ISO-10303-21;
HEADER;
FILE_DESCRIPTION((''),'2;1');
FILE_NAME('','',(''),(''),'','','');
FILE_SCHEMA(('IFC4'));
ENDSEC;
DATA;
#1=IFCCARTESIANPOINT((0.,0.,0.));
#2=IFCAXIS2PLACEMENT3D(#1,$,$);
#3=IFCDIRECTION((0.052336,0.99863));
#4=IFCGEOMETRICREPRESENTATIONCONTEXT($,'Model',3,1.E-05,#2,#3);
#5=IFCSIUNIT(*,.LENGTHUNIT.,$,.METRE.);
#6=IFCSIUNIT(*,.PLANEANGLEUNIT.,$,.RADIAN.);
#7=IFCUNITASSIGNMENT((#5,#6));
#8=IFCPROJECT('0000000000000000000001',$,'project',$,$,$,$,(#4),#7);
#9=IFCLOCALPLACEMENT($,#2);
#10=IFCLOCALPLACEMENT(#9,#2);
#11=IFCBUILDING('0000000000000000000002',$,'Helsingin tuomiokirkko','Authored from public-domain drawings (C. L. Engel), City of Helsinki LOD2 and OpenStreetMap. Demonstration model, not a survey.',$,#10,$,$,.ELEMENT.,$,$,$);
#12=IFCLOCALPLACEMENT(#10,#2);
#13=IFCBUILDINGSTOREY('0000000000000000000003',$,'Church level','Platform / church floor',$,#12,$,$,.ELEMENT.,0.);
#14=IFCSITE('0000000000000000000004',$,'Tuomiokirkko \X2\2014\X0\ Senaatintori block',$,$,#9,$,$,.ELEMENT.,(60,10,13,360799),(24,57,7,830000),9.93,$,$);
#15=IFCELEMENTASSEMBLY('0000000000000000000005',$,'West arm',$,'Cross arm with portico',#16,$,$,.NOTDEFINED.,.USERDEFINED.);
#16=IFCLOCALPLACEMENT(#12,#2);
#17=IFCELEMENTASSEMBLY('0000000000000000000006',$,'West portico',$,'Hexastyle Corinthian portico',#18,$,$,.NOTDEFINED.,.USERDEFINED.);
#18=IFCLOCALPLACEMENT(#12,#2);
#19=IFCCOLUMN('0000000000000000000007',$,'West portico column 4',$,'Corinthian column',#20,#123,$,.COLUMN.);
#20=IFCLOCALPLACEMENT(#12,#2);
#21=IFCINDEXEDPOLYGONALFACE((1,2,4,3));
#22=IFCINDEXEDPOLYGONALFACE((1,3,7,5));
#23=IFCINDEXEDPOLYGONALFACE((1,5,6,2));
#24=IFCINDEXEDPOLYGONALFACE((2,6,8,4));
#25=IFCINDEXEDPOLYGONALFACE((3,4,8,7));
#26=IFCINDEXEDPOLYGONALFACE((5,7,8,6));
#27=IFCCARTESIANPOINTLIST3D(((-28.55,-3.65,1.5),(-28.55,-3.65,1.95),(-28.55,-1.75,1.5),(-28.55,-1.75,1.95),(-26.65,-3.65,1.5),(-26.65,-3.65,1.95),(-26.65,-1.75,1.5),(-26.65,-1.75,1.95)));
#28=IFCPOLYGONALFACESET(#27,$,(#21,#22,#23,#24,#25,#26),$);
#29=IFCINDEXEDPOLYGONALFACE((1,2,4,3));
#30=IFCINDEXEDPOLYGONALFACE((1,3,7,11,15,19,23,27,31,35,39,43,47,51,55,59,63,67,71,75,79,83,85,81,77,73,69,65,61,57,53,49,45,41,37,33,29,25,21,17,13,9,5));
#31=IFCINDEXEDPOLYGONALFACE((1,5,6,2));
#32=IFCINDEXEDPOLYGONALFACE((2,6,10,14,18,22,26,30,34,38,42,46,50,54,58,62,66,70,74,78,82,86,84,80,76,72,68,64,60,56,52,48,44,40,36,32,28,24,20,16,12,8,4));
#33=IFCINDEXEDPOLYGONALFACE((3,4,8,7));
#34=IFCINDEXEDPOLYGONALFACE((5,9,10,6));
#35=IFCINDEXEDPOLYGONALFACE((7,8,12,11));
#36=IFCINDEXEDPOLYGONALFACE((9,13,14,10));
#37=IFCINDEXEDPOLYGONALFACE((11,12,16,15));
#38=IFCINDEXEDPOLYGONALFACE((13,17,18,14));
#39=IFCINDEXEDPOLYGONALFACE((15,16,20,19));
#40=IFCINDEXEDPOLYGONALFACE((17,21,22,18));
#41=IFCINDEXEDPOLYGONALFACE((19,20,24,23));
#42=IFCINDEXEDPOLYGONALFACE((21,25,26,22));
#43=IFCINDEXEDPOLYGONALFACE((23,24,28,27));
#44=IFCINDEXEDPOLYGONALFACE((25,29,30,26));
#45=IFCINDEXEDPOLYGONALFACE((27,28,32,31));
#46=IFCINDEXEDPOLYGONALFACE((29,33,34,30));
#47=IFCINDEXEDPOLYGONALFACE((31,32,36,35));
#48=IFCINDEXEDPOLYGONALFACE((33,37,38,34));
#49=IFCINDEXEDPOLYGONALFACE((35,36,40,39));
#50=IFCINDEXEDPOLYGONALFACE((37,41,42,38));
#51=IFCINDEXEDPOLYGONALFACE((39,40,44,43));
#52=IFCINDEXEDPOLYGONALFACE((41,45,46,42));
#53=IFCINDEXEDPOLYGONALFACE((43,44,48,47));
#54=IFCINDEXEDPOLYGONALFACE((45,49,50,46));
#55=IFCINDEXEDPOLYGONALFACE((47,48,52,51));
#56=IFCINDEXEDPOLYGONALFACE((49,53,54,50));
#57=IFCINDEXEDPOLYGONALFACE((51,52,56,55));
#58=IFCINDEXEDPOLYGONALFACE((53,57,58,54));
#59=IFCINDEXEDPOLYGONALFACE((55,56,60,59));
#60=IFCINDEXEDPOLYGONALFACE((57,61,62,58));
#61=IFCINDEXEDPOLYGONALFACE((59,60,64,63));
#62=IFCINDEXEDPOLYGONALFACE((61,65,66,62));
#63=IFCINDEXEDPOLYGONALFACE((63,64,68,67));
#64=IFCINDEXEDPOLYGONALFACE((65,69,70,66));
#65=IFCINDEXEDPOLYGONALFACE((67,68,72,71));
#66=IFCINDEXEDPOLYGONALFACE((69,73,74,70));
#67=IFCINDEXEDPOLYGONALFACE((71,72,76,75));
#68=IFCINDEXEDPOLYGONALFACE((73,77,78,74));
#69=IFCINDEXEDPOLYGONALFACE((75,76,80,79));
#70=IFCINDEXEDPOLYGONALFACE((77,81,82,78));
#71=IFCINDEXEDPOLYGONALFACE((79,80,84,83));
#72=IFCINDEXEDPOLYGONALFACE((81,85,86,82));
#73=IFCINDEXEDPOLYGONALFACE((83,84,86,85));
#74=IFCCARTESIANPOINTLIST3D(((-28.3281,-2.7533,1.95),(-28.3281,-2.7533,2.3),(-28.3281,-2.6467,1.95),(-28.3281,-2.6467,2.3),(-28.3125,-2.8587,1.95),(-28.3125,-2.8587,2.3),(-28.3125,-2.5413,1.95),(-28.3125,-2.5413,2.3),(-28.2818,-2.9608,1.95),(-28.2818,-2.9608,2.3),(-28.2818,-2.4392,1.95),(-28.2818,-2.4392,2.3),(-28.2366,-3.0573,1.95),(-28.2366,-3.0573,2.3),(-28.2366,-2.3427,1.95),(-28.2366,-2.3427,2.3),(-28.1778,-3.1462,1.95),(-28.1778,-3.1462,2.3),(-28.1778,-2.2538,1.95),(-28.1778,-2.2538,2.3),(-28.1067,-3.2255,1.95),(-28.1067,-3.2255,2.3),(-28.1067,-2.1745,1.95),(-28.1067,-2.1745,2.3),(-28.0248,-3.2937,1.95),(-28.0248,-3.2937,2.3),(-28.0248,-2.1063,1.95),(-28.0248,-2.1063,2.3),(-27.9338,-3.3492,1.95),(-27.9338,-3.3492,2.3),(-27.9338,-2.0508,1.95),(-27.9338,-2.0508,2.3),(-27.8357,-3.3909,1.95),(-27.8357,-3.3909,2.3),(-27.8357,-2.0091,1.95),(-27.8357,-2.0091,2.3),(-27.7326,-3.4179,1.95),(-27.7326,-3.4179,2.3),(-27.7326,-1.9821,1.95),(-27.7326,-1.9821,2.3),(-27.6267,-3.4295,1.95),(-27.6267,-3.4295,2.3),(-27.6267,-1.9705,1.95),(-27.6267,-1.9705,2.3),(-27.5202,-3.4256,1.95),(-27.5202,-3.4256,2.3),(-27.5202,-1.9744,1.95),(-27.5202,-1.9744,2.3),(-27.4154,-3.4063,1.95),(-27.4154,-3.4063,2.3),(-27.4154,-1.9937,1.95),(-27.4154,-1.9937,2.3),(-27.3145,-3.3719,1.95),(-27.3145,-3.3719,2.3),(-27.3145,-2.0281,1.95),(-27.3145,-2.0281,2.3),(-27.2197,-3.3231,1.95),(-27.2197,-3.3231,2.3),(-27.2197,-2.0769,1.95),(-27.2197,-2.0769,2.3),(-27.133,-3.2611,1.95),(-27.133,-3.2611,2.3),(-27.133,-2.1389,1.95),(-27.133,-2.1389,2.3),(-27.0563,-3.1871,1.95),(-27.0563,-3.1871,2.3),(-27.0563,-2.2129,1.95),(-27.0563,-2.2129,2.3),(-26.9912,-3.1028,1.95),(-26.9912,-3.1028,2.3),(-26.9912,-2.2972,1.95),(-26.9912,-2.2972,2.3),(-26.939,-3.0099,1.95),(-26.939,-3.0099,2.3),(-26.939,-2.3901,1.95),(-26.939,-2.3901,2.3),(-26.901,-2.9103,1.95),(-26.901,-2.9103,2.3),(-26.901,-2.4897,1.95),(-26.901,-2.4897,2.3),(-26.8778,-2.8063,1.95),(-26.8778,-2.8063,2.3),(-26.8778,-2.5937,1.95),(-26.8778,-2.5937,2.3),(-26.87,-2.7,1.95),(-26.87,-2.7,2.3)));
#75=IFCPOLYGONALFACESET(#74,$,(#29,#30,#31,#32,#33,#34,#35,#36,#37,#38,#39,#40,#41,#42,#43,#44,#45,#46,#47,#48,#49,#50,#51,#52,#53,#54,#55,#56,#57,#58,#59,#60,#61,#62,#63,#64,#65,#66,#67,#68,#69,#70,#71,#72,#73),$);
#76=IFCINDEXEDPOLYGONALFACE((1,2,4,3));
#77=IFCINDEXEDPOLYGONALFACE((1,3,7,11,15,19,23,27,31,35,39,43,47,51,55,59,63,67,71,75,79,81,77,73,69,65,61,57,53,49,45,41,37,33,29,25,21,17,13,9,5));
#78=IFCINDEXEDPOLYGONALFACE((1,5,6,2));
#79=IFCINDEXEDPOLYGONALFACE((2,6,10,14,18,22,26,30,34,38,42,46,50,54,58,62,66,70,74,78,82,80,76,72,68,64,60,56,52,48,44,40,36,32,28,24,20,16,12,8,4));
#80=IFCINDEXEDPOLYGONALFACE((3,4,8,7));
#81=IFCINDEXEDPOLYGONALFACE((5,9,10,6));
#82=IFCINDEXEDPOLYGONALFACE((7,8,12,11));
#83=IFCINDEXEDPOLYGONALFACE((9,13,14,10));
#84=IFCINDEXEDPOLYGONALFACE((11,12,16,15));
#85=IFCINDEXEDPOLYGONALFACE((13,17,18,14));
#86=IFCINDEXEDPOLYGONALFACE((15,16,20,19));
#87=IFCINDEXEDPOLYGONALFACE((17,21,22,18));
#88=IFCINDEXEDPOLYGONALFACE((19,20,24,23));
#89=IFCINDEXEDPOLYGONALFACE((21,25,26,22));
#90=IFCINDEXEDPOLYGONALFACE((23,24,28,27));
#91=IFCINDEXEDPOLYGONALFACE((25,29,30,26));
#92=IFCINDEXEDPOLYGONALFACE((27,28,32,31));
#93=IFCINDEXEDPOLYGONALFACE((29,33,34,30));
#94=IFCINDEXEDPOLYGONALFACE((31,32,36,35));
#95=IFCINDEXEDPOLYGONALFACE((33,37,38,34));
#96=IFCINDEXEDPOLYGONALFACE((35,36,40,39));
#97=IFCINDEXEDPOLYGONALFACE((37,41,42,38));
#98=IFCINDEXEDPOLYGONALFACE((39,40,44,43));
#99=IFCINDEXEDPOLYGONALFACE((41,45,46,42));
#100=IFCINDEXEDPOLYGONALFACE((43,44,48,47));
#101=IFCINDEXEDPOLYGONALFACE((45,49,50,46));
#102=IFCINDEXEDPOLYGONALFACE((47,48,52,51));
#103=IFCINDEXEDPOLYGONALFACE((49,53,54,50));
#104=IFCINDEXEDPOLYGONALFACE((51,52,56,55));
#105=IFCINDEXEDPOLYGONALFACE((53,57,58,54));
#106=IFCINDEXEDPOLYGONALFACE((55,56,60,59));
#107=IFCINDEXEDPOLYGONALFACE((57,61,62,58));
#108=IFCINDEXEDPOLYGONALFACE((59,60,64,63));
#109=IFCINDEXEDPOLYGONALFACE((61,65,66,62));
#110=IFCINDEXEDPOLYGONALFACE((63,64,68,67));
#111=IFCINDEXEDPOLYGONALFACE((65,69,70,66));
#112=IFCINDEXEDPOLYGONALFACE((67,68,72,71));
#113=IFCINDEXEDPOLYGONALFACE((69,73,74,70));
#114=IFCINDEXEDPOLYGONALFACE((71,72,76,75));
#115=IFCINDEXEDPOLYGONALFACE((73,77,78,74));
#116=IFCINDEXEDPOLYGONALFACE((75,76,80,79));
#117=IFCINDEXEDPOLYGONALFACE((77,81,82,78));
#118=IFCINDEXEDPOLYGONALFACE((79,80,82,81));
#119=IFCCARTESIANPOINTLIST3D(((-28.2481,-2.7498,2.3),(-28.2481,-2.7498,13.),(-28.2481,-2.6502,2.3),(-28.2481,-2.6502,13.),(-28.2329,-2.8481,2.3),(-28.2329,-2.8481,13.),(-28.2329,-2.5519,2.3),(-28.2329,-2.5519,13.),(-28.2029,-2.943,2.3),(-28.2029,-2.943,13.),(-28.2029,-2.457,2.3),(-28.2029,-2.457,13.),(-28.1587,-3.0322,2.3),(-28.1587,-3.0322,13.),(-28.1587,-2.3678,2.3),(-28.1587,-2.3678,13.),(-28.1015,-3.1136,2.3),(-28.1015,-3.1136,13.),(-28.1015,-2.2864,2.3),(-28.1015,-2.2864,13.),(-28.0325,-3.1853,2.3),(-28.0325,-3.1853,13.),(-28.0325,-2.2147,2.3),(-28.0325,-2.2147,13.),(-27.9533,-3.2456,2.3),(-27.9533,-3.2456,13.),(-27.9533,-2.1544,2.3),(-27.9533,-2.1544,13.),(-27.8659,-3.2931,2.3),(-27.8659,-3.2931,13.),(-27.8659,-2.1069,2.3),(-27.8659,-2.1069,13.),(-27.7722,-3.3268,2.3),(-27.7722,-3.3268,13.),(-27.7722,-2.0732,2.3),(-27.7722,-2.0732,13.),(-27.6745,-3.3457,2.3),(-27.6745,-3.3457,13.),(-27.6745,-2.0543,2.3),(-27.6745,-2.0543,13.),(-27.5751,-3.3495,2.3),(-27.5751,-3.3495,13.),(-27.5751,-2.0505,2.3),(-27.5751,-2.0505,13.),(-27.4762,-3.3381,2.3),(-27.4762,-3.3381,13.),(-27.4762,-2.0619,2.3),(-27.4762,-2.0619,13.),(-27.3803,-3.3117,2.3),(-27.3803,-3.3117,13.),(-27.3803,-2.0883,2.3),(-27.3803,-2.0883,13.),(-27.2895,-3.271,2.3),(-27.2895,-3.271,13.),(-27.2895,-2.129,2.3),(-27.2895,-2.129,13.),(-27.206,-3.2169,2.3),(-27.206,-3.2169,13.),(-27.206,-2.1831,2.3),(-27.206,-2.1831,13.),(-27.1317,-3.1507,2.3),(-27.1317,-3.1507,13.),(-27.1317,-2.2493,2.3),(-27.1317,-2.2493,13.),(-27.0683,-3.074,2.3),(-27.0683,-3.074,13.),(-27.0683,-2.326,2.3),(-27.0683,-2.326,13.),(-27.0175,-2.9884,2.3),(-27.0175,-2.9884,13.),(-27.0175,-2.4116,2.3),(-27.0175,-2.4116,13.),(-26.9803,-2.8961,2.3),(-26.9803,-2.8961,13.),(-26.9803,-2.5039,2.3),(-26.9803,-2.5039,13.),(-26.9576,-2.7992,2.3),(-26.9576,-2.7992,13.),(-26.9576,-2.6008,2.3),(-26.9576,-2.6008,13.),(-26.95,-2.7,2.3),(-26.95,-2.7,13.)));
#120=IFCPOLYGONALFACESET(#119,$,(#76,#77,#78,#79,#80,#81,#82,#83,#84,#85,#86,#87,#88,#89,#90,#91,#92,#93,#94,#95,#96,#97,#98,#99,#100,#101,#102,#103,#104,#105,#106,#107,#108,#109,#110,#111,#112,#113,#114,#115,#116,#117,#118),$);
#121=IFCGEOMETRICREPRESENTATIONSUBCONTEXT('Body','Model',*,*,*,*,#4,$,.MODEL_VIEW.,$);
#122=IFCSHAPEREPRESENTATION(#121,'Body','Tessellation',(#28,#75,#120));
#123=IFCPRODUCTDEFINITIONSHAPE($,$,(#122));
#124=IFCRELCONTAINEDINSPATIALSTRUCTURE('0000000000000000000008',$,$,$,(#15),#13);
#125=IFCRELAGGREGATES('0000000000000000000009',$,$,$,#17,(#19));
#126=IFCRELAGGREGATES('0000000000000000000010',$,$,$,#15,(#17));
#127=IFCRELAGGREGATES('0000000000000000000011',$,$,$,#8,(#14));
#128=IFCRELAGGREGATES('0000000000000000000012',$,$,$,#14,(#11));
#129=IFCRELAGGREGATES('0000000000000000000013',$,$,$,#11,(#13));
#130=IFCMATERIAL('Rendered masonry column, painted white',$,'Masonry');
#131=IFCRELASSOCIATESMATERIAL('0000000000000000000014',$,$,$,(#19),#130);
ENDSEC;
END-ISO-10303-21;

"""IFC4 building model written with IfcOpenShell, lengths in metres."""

from ifc_helpers import new_model, si_unit, direction, frame, origin, origin_2d_with_axis, place, context, subcontext, project, spatial, rectangle, circle, extrude, material, element, aggregate, save


model = new_model("IFC4")

# Units and contexts
model_context = context("Model", 3, precision=1e-05, world=origin(), true_north=direction((0.052336, 0.99863)))
body_context = subcontext(model_context, "Body", "Model", "MODEL_VIEW")
ifc_project = project(units=[si_unit("LENGTHUNIT", "METRE"), si_unit("PLANEANGLEUNIT", "RADIAN")], contexts=[model_context])

# Site, building, storey
site_placement = place(None, origin())
site = spatial("IfcSite", under=ifc_project, at=site_placement, Name="Tuomiokirkko — Senaatintori block", CompositionType="ELEMENT", RefLatitude=(60, 10, 13, 360799), RefLongitude=(24, 57, 7, 830000), RefElevation=9.93)
building_placement = place(site_placement, origin())
building = spatial("IfcBuilding", under=site, at=building_placement, Name="Helsingin tuomiokirkko", Description="Authored from public-domain drawings (C. L. Engel), City of Helsinki LOD2 and OpenStreetMap. Demonstration model, not a survey.", CompositionType="ELEMENT")
storey_placement = place(building_placement, origin())
storey = spatial("IfcBuildingStorey", under=building, at=storey_placement, Name="Church level", Description="Platform / church floor", CompositionType="ELEMENT", Elevation=0.0)

# Element assemblies, column
assembly_1_placement = place(building_placement, origin())
assembly_1 = element("IfcElementAssembly", 1, at=assembly_1_placement, inside=storey, Name="West arm", ObjectType="Cross arm with portico", AssemblyPlace="NOTDEFINED", PredefinedType="USERDEFINED")
assembly_2_placement = place(building_placement, origin())
assembly_2 = element("IfcElementAssembly", 2, at=assembly_2_placement, Name="West portico", ObjectType="Hexastyle Corinthian portico", AssemblyPlace="NOTDEFINED", PredefinedType="USERDEFINED")
ifc_material_1 = material(Name="Rendered masonry column, painted white", Category="Masonry")
column_1_placement = place(building_placement, origin())
column_1 = element("IfcColumn", 3, at=column_1_placement, material=ifc_material_1, Name="West portico column 4", ObjectType="Corinthian column", PredefinedType="COLUMN", context=body_context, shape_type="SweptSolid", body=[
    extrude(rectangle(XDim=1.9, YDim=1.9, at=origin_2d_with_axis()), frame((-27.6, -2.7, 1.5)), (0.0, 0.0, 1.0), 0.45),
    extrude(circle(Radius=0.73, at=origin_2d_with_axis()), frame((-27.6, -2.7, 1.95)), (0.0, 0.0, 1.0), 0.35),
    extrude(circle(Radius=0.65, at=origin_2d_with_axis()), frame((-27.6, -2.7, 2.3)), (0.0, 0.0, 1.0), 10.7),
])

aggregate(assembly_2, [column_1])

aggregate(assembly_1, [assembly_2])

save(model, "model.ifc")
